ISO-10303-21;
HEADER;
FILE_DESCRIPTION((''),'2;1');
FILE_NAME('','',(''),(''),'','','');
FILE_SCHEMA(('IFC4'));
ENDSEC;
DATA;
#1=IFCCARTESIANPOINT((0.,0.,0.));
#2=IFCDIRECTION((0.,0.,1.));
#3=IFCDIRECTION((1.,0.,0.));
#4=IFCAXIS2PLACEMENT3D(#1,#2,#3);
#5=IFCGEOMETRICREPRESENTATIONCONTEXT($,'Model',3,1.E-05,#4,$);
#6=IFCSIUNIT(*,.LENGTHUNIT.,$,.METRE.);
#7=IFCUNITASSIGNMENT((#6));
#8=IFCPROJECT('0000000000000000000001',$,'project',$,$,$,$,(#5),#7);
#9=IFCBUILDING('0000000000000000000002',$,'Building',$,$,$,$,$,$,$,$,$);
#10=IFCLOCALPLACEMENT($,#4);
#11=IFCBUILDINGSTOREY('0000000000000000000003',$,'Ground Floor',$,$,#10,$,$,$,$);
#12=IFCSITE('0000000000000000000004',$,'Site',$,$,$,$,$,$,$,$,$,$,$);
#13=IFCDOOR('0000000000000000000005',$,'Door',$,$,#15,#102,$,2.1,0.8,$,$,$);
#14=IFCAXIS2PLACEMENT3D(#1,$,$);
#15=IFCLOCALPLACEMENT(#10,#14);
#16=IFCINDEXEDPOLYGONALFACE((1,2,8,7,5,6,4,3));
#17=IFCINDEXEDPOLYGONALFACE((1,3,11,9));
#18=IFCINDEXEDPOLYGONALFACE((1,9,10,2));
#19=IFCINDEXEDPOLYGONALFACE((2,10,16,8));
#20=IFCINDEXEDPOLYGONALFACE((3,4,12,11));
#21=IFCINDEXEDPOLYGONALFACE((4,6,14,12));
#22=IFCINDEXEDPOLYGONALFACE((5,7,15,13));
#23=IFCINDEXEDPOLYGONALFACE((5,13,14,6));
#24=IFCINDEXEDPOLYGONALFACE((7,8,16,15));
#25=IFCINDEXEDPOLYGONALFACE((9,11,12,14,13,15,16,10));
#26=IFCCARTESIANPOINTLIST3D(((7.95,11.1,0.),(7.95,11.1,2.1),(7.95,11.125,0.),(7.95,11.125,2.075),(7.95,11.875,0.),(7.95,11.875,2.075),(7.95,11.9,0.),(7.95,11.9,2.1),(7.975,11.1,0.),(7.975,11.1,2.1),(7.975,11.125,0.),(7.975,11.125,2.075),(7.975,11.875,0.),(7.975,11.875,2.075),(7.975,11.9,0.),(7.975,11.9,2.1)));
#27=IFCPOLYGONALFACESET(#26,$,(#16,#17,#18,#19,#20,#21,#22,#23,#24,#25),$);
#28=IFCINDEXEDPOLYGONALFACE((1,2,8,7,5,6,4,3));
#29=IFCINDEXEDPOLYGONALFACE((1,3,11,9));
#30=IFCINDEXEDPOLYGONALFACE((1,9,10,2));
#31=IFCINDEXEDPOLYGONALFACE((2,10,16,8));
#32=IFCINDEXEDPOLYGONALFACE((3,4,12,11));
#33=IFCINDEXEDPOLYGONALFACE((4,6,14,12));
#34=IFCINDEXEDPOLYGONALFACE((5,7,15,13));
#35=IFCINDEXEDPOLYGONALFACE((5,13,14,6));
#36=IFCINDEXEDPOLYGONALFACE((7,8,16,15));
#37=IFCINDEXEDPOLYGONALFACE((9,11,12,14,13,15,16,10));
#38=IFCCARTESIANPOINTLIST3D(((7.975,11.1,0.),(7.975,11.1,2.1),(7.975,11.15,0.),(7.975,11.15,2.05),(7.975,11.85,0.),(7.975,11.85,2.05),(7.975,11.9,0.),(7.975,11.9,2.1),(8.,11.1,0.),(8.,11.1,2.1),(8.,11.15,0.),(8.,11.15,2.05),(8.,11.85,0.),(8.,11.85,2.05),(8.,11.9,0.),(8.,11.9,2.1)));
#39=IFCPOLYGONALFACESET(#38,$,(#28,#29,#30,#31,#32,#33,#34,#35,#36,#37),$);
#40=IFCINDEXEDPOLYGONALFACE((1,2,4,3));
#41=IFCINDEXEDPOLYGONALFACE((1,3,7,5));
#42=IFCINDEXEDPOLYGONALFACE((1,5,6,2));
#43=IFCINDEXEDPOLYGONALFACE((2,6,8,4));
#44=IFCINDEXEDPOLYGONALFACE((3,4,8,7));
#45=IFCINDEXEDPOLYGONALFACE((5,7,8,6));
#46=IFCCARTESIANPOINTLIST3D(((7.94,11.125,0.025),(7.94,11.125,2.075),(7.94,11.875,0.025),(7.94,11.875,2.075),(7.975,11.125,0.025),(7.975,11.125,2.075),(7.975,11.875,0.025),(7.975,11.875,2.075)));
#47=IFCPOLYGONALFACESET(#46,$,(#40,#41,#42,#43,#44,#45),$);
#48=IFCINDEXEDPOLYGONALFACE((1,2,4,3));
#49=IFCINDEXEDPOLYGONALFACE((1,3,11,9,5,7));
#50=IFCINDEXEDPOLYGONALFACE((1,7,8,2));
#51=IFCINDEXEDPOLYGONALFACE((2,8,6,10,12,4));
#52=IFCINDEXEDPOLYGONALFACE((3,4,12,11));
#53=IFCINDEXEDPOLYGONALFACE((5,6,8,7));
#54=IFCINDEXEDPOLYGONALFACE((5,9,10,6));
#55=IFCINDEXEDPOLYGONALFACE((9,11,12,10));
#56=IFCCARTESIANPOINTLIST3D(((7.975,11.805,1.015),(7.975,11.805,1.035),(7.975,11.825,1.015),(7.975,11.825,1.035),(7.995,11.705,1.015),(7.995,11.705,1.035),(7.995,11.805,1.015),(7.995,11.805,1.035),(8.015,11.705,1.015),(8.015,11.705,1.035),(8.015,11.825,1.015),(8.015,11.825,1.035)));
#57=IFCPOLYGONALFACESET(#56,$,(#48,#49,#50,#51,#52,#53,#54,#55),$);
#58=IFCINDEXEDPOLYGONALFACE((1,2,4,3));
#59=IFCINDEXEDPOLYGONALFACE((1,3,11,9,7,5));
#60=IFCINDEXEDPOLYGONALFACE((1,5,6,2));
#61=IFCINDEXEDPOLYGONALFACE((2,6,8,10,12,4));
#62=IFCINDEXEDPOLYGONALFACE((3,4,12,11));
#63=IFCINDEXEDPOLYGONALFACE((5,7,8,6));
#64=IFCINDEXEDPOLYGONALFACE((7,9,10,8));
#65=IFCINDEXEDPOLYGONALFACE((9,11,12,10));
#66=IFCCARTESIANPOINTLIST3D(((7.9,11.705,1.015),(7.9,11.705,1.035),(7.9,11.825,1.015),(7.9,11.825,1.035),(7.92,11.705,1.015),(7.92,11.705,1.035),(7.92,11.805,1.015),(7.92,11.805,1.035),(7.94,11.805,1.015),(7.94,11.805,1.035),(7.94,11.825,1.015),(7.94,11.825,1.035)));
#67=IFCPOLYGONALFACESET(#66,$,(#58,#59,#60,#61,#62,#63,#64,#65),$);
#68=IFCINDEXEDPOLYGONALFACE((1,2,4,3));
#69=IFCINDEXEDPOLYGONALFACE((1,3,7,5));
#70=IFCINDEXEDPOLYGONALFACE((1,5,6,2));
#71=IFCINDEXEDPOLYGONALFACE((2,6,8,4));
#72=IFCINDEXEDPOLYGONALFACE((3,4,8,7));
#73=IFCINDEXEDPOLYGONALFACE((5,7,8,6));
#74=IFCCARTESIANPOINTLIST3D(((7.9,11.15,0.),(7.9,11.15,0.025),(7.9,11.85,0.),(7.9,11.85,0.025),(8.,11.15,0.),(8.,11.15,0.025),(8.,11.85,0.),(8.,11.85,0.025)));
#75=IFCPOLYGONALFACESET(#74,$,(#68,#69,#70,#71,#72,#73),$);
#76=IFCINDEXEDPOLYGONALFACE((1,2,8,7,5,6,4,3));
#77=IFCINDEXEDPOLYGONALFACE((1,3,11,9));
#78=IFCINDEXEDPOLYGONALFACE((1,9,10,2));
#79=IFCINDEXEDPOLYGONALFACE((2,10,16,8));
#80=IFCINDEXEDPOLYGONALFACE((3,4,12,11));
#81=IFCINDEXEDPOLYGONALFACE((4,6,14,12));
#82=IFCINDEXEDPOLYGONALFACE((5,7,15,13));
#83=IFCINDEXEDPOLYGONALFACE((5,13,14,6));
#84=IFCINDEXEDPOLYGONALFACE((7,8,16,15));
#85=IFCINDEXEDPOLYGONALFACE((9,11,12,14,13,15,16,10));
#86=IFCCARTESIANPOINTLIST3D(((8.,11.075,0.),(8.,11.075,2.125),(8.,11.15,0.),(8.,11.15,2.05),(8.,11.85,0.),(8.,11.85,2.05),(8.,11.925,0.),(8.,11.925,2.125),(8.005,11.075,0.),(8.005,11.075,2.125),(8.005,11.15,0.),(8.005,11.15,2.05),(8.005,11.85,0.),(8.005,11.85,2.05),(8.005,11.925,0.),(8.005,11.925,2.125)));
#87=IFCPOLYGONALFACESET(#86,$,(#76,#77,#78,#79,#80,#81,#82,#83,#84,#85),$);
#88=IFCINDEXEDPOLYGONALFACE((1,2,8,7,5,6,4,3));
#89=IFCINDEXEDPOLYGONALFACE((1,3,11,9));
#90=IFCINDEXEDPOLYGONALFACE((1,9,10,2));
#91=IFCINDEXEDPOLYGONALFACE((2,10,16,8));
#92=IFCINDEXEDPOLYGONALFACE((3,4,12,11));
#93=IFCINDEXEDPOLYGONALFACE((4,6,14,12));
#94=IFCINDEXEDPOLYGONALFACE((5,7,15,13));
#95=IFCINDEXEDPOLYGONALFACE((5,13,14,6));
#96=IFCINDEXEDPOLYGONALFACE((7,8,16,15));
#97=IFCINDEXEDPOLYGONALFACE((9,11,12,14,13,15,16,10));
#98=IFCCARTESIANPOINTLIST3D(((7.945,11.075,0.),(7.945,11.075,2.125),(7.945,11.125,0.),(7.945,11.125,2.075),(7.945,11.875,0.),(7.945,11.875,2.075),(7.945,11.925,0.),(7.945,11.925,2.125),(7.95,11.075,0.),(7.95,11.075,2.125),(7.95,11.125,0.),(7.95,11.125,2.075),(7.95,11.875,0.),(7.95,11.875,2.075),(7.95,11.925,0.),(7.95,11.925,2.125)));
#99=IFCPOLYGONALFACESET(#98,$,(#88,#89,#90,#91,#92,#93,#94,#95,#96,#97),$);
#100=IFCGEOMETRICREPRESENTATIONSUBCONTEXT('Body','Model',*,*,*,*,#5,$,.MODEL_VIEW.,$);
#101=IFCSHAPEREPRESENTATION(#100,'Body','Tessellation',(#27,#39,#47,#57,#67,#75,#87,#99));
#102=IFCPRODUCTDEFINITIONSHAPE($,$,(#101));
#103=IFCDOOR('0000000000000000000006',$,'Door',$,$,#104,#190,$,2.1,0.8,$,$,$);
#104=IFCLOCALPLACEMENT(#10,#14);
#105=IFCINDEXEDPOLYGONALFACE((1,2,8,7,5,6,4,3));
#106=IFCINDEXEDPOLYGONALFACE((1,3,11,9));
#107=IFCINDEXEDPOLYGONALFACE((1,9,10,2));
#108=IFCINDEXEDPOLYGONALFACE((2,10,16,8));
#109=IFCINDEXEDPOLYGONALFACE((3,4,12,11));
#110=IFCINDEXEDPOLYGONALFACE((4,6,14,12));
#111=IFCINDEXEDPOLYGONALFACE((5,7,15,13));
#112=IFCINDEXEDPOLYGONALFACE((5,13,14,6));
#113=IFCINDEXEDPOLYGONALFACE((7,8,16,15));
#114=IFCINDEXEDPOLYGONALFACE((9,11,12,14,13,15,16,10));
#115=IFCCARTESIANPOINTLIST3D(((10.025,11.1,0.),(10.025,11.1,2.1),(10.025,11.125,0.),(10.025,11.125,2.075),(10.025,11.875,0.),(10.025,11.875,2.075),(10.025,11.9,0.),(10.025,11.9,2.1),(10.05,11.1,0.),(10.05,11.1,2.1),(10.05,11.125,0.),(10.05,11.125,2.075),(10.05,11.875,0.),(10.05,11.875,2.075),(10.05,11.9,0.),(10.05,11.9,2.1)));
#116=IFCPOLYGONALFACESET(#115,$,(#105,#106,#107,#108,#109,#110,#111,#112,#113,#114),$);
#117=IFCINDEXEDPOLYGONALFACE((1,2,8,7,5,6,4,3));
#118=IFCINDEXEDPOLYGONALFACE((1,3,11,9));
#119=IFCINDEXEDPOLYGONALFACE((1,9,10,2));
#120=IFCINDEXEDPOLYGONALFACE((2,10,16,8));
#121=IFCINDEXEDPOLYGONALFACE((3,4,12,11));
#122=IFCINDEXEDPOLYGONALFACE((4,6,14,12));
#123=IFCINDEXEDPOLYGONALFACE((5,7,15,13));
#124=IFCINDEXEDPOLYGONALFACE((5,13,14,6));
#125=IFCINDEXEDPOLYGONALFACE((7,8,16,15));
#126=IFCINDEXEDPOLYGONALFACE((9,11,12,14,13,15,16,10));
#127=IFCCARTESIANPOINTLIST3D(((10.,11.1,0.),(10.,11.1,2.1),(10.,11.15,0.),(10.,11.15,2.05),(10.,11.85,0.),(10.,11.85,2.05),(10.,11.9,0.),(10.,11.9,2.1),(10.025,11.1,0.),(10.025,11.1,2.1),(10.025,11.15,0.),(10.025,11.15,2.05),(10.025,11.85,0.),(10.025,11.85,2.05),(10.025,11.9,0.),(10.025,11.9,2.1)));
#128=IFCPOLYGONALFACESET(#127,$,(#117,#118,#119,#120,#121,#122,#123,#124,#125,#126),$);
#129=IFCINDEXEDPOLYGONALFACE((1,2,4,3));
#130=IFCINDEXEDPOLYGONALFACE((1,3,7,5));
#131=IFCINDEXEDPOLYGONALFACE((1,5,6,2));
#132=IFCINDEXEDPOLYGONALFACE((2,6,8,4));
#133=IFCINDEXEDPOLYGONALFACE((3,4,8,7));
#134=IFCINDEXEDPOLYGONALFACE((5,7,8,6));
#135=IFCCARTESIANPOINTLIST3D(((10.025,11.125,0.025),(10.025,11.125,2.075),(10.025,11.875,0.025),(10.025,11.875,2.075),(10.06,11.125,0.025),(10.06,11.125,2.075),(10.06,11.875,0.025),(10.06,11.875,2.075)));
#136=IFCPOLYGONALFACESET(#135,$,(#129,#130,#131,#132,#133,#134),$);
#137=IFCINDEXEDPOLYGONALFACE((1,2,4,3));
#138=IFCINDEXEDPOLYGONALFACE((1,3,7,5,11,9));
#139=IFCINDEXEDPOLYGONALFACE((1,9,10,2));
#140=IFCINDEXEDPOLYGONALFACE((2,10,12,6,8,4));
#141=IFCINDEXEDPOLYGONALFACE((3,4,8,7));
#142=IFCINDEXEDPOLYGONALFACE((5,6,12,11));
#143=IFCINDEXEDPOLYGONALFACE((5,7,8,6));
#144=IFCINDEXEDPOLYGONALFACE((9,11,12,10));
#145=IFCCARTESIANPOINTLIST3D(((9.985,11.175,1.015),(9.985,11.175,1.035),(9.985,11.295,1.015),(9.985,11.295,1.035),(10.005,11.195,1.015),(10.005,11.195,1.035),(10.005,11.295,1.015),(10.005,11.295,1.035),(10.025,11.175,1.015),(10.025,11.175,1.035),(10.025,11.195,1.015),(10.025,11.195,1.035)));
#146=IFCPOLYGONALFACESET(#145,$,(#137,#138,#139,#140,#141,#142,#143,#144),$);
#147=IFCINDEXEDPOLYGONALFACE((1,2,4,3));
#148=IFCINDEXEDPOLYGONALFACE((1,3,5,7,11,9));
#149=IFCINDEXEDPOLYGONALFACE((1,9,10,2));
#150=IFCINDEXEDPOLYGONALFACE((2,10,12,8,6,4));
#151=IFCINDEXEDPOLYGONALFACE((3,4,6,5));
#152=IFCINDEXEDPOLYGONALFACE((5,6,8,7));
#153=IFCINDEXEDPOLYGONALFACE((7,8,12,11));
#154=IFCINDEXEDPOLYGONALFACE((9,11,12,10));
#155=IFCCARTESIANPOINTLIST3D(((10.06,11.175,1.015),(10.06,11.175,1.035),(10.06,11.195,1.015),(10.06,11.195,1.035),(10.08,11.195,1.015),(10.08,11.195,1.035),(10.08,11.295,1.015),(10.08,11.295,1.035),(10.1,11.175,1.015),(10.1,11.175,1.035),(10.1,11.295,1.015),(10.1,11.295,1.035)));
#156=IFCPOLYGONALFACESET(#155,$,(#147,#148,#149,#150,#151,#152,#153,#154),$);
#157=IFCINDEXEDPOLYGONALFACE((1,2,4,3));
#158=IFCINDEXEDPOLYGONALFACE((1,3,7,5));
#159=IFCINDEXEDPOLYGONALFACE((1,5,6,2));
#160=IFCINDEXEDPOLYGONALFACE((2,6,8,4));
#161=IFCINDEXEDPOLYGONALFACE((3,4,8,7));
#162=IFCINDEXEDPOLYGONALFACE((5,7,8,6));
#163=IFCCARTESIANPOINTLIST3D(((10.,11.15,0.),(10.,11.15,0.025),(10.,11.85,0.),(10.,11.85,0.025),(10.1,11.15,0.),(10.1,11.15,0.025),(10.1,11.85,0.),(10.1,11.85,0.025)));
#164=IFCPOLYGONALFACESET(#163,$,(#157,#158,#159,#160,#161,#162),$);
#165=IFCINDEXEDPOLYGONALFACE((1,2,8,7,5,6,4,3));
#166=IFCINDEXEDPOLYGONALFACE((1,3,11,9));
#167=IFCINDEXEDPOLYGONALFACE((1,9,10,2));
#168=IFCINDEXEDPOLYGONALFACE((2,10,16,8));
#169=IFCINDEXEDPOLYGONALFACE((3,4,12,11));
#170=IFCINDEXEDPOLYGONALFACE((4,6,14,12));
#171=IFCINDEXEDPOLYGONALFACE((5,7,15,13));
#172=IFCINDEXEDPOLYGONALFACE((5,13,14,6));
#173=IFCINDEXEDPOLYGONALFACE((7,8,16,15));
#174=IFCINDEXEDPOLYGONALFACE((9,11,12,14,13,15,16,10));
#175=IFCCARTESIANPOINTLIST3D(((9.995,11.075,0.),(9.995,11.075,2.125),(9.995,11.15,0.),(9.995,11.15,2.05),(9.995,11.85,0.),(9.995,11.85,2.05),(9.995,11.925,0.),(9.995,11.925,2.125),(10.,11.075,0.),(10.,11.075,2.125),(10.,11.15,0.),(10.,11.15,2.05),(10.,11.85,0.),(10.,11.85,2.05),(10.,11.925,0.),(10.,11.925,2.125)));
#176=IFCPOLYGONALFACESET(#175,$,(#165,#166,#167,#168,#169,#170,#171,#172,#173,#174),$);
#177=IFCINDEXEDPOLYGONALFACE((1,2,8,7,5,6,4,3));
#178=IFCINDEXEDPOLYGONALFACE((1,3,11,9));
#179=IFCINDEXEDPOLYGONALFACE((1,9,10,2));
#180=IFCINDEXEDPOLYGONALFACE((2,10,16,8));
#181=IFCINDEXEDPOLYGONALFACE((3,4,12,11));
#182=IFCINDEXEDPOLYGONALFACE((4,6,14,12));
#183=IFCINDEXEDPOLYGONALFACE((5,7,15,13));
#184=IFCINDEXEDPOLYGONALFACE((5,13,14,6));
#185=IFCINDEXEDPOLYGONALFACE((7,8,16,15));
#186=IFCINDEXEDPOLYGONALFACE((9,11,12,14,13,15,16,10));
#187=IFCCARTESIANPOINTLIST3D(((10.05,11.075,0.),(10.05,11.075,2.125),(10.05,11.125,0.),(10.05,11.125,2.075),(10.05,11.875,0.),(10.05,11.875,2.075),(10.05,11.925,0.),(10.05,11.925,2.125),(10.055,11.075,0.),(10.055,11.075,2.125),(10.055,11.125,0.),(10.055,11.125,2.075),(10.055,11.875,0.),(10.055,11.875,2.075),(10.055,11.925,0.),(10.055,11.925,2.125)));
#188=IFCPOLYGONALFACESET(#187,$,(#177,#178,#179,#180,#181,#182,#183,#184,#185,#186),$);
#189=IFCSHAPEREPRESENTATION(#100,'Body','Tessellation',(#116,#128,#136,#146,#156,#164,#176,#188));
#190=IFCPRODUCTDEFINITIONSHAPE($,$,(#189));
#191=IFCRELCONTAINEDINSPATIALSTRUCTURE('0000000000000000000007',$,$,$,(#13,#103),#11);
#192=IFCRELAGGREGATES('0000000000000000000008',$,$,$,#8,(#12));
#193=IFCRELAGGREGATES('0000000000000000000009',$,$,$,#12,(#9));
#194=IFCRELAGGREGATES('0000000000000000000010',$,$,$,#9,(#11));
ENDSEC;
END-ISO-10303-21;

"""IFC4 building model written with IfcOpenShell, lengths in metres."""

from ifc_helpers import new_model, si_unit, frame, origin_with_axes, place, context, subcontext, project, spatial, line, indexed_curve, outline, extrude, element, save


model = new_model("IFC4")

# Units and contexts
model_context = context("Model", 3, precision=1e-05, world=origin_with_axes())
body_context = subcontext(model_context, "Body", "Model", "MODEL_VIEW")
ifc_project = project(units=[si_unit("LENGTHUNIT", "METRE")], contexts=[model_context])

# Site, building, storey
site = spatial("IfcSite", under=ifc_project, Name="Site")
building = spatial("IfcBuilding", under=site, Name="Building")
storey_placement = place(None, origin_with_axes())
storey = spatial("IfcBuildingStorey", under=building, at=storey_placement, Name="Ground Floor")

# Doors
door_1_placement = place(storey_placement, frame((8.0, 11.1, 0.0), z_axis=(0.0, 0.0, 1.0), x_axis=(0.0, 1.0, 0.0)))
element("IfcDoor", 1, at=door_1_placement, inside=storey, Name="Door", OverallHeight=2.1, OverallWidth=0.8, context=body_context, shape_type="SweptSolid", body=[
    extrude(outline(indexed_curve([(0.0, 0.0), (0.0, 2.1), (0.8, 2.1), (0.8, 0.0), (0.775, 0.0), (0.775, 2.075), (0.025, 2.075), (0.025, 0.0)], segments=[line(1, 2, 3, 4, 5, 6, 7, 8, 1)])), frame((0.0, 0.025, 0.0), z_axis=(0.0, -1.0, 0.0), x_axis=(1.0, 0.0, 0.0)), (0.0, 0.0, -1.0), 0.025),
    extrude(outline(indexed_curve([(0.0, 0.0), (0.0, 2.1), (0.8, 2.1), (0.8, 0.0), (0.75, 0.0), (0.75, 2.05), (0.05, 2.05), (0.05, 0.0)], segments=[line(1, 2, 3, 4, 5, 6, 7, 8, 1)])), frame((0.0, 0.0, 0.0), z_axis=(0.0, -1.0, 0.0), x_axis=(1.0, 0.0, 0.0)), (0.0, 0.0, -1.0), 0.025),
    extrude(outline(indexed_curve([(0.0, 0.0), (0.75, 0.0), (0.75, 0.035), (0.0, 0.035)], segments=[line(1, 2, 3, 4, 1)])), frame((0.025, 0.025, 0.025), z_axis=(0.0, 0.0, 1.0), x_axis=(1.0, 0.0, 0.0)), (0.0, 0.0, 1.0), 2.05),
    extrude(outline(indexed_curve([(0.0, 0.0), (0.0, -0.04), (-0.12, -0.04), (-0.12, -0.02), (-0.02, -0.02), (-0.02, 0.0)], segments=[line(1, 2, 3, 4, 5, 6, 1)])), frame((0.725, 0.025, 1.015), z_axis=(0.0, 0.0, 1.0), x_axis=(1.0, 0.0, 0.0)), (0.0, 0.0, 1.0), 0.02),
    extrude(outline(indexed_curve([(0.0, 0.0), (0.0, 0.04), (-0.12, 0.04), (-0.12, 0.02), (-0.02, 0.02), (-0.02, 0.0)], segments=[line(1, 2, 3, 4, 5, 6, 1)])), frame((0.725, 0.06, 1.015), z_axis=(0.0, 0.0, 1.0), x_axis=(1.0, 0.0, 0.0)), (0.0, 0.0, 1.0), 0.02),
    extrude(outline(indexed_curve([(0.0, 0.0), (0.7, 0.0), (0.7, 0.1), (0.0, 0.1)], segments=[line(1, 2, 3, 4, 1)])), frame((0.05, 0.0, 0.0), z_axis=(0.0, 0.0, 1.0), x_axis=(1.0, 0.0, 0.0)), (0.0, 0.0, 1.0), 0.025),
    extrude(outline(indexed_curve([(0.0, 0.0), (0.0, 2.125), (0.85, 2.125), (0.85, 0.0), (0.775, 0.0), (0.775, 2.05), (0.075, 2.05), (0.075, 0.0)], segments=[line(1, 2, 3, 4, 5, 6, 7, 8, 1)])), frame((-0.025, -0.005, 0.0), z_axis=(0.0, -1.0, 0.0), x_axis=(1.0, 0.0, 0.0)), (0.0, 0.0, -1.0), 0.005),
    extrude(outline(indexed_curve([(0.0, 0.0), (0.0, 2.125), (0.85, 2.125), (0.85, 0.0), (0.8, 0.0), (0.8, 2.075), (0.05, 2.075), (0.05, 0.0)], segments=[line(1, 2, 3, 4, 5, 6, 7, 8, 1)])), frame((-0.025, 0.05, 0.0), z_axis=(0.0, -1.0, 0.0), x_axis=(1.0, 0.0, 0.0)), (0.0, 0.0, -1.0), 0.005),
])
door_2_placement = place(storey_placement, frame((10.0, 11.9, 0.0), z_axis=(0.0, 0.0, 1.0), x_axis=(0.0, -1.0, 0.0)))
element("IfcDoor", 2, at=door_2_placement, inside=storey, Name="Door", OverallHeight=2.1, OverallWidth=0.8, context=body_context, shape_type="SweptSolid", body=[
    extrude(outline(indexed_curve([(0.0, 0.0), (0.0, 2.1), (0.8, 2.1), (0.8, 0.0), (0.775, 0.0), (0.775, 2.075), (0.025, 2.075), (0.025, 0.0)], segments=[line(1, 2, 3, 4, 5, 6, 7, 8, 1)])), frame((0.0, 0.025, 0.0), z_axis=(0.0, -1.0, 0.0), x_axis=(1.0, 0.0, 0.0)), (0.0, 0.0, -1.0), 0.025),
    extrude(outline(indexed_curve([(0.0, 0.0), (0.0, 2.1), (0.8, 2.1), (0.8, 0.0), (0.75, 0.0), (0.75, 2.05), (0.05, 2.05), (0.05, 0.0)], segments=[line(1, 2, 3, 4, 5, 6, 7, 8, 1)])), frame((0.0, 0.0, 0.0), z_axis=(0.0, -1.0, 0.0), x_axis=(1.0, 0.0, 0.0)), (0.0, 0.0, -1.0), 0.025),
    extrude(outline(indexed_curve([(0.0, 0.0), (0.75, 0.0), (0.75, 0.035), (0.0, 0.035)], segments=[line(1, 2, 3, 4, 1)])), frame((0.025, 0.025, 0.025), z_axis=(0.0, 0.0, 1.0), x_axis=(1.0, 0.0, 0.0)), (0.0, 0.0, 1.0), 2.05),
    extrude(outline(indexed_curve([(0.0, 0.0), (0.0, -0.04), (-0.12, -0.04), (-0.12, -0.02), (-0.02, -0.02), (-0.02, 0.0)], segments=[line(1, 2, 3, 4, 5, 6, 1)])), frame((0.725, 0.025, 1.015), z_axis=(0.0, 0.0, 1.0), x_axis=(1.0, 0.0, 0.0)), (0.0, 0.0, 1.0), 0.02),
    extrude(outline(indexed_curve([(0.0, 0.0), (0.0, 0.04), (-0.12, 0.04), (-0.12, 0.02), (-0.02, 0.02), (-0.02, 0.0)], segments=[line(1, 2, 3, 4, 5, 6, 1)])), frame((0.725, 0.06, 1.015), z_axis=(0.0, 0.0, 1.0), x_axis=(1.0, 0.0, 0.0)), (0.0, 0.0, 1.0), 0.02),
    extrude(outline(indexed_curve([(0.0, 0.0), (0.7, 0.0), (0.7, 0.1), (0.0, 0.1)], segments=[line(1, 2, 3, 4, 1)])), frame((0.05, 0.0, 0.0), z_axis=(0.0, 0.0, 1.0), x_axis=(1.0, 0.0, 0.0)), (0.0, 0.0, 1.0), 0.025),
    extrude(outline(indexed_curve([(0.0, 0.0), (0.0, 2.125), (0.85, 2.125), (0.85, 0.0), (0.775, 0.0), (0.775, 2.05), (0.075, 2.05), (0.075, 0.0)], segments=[line(1, 2, 3, 4, 5, 6, 7, 8, 1)])), frame((-0.025, -0.005, 0.0), z_axis=(0.0, -1.0, 0.0), x_axis=(1.0, 0.0, 0.0)), (0.0, 0.0, -1.0), 0.005),
    extrude(outline(indexed_curve([(0.0, 0.0), (0.0, 2.125), (0.85, 2.125), (0.85, 0.0), (0.8, 0.0), (0.8, 2.075), (0.05, 2.075), (0.05, 0.0)], segments=[line(1, 2, 3, 4, 5, 6, 7, 8, 1)])), frame((-0.025, 0.05, 0.0), z_axis=(0.0, -1.0, 0.0), x_axis=(1.0, 0.0, 0.0)), (0.0, 0.0, -1.0), 0.005),
])

save(model, "model.ifc")
